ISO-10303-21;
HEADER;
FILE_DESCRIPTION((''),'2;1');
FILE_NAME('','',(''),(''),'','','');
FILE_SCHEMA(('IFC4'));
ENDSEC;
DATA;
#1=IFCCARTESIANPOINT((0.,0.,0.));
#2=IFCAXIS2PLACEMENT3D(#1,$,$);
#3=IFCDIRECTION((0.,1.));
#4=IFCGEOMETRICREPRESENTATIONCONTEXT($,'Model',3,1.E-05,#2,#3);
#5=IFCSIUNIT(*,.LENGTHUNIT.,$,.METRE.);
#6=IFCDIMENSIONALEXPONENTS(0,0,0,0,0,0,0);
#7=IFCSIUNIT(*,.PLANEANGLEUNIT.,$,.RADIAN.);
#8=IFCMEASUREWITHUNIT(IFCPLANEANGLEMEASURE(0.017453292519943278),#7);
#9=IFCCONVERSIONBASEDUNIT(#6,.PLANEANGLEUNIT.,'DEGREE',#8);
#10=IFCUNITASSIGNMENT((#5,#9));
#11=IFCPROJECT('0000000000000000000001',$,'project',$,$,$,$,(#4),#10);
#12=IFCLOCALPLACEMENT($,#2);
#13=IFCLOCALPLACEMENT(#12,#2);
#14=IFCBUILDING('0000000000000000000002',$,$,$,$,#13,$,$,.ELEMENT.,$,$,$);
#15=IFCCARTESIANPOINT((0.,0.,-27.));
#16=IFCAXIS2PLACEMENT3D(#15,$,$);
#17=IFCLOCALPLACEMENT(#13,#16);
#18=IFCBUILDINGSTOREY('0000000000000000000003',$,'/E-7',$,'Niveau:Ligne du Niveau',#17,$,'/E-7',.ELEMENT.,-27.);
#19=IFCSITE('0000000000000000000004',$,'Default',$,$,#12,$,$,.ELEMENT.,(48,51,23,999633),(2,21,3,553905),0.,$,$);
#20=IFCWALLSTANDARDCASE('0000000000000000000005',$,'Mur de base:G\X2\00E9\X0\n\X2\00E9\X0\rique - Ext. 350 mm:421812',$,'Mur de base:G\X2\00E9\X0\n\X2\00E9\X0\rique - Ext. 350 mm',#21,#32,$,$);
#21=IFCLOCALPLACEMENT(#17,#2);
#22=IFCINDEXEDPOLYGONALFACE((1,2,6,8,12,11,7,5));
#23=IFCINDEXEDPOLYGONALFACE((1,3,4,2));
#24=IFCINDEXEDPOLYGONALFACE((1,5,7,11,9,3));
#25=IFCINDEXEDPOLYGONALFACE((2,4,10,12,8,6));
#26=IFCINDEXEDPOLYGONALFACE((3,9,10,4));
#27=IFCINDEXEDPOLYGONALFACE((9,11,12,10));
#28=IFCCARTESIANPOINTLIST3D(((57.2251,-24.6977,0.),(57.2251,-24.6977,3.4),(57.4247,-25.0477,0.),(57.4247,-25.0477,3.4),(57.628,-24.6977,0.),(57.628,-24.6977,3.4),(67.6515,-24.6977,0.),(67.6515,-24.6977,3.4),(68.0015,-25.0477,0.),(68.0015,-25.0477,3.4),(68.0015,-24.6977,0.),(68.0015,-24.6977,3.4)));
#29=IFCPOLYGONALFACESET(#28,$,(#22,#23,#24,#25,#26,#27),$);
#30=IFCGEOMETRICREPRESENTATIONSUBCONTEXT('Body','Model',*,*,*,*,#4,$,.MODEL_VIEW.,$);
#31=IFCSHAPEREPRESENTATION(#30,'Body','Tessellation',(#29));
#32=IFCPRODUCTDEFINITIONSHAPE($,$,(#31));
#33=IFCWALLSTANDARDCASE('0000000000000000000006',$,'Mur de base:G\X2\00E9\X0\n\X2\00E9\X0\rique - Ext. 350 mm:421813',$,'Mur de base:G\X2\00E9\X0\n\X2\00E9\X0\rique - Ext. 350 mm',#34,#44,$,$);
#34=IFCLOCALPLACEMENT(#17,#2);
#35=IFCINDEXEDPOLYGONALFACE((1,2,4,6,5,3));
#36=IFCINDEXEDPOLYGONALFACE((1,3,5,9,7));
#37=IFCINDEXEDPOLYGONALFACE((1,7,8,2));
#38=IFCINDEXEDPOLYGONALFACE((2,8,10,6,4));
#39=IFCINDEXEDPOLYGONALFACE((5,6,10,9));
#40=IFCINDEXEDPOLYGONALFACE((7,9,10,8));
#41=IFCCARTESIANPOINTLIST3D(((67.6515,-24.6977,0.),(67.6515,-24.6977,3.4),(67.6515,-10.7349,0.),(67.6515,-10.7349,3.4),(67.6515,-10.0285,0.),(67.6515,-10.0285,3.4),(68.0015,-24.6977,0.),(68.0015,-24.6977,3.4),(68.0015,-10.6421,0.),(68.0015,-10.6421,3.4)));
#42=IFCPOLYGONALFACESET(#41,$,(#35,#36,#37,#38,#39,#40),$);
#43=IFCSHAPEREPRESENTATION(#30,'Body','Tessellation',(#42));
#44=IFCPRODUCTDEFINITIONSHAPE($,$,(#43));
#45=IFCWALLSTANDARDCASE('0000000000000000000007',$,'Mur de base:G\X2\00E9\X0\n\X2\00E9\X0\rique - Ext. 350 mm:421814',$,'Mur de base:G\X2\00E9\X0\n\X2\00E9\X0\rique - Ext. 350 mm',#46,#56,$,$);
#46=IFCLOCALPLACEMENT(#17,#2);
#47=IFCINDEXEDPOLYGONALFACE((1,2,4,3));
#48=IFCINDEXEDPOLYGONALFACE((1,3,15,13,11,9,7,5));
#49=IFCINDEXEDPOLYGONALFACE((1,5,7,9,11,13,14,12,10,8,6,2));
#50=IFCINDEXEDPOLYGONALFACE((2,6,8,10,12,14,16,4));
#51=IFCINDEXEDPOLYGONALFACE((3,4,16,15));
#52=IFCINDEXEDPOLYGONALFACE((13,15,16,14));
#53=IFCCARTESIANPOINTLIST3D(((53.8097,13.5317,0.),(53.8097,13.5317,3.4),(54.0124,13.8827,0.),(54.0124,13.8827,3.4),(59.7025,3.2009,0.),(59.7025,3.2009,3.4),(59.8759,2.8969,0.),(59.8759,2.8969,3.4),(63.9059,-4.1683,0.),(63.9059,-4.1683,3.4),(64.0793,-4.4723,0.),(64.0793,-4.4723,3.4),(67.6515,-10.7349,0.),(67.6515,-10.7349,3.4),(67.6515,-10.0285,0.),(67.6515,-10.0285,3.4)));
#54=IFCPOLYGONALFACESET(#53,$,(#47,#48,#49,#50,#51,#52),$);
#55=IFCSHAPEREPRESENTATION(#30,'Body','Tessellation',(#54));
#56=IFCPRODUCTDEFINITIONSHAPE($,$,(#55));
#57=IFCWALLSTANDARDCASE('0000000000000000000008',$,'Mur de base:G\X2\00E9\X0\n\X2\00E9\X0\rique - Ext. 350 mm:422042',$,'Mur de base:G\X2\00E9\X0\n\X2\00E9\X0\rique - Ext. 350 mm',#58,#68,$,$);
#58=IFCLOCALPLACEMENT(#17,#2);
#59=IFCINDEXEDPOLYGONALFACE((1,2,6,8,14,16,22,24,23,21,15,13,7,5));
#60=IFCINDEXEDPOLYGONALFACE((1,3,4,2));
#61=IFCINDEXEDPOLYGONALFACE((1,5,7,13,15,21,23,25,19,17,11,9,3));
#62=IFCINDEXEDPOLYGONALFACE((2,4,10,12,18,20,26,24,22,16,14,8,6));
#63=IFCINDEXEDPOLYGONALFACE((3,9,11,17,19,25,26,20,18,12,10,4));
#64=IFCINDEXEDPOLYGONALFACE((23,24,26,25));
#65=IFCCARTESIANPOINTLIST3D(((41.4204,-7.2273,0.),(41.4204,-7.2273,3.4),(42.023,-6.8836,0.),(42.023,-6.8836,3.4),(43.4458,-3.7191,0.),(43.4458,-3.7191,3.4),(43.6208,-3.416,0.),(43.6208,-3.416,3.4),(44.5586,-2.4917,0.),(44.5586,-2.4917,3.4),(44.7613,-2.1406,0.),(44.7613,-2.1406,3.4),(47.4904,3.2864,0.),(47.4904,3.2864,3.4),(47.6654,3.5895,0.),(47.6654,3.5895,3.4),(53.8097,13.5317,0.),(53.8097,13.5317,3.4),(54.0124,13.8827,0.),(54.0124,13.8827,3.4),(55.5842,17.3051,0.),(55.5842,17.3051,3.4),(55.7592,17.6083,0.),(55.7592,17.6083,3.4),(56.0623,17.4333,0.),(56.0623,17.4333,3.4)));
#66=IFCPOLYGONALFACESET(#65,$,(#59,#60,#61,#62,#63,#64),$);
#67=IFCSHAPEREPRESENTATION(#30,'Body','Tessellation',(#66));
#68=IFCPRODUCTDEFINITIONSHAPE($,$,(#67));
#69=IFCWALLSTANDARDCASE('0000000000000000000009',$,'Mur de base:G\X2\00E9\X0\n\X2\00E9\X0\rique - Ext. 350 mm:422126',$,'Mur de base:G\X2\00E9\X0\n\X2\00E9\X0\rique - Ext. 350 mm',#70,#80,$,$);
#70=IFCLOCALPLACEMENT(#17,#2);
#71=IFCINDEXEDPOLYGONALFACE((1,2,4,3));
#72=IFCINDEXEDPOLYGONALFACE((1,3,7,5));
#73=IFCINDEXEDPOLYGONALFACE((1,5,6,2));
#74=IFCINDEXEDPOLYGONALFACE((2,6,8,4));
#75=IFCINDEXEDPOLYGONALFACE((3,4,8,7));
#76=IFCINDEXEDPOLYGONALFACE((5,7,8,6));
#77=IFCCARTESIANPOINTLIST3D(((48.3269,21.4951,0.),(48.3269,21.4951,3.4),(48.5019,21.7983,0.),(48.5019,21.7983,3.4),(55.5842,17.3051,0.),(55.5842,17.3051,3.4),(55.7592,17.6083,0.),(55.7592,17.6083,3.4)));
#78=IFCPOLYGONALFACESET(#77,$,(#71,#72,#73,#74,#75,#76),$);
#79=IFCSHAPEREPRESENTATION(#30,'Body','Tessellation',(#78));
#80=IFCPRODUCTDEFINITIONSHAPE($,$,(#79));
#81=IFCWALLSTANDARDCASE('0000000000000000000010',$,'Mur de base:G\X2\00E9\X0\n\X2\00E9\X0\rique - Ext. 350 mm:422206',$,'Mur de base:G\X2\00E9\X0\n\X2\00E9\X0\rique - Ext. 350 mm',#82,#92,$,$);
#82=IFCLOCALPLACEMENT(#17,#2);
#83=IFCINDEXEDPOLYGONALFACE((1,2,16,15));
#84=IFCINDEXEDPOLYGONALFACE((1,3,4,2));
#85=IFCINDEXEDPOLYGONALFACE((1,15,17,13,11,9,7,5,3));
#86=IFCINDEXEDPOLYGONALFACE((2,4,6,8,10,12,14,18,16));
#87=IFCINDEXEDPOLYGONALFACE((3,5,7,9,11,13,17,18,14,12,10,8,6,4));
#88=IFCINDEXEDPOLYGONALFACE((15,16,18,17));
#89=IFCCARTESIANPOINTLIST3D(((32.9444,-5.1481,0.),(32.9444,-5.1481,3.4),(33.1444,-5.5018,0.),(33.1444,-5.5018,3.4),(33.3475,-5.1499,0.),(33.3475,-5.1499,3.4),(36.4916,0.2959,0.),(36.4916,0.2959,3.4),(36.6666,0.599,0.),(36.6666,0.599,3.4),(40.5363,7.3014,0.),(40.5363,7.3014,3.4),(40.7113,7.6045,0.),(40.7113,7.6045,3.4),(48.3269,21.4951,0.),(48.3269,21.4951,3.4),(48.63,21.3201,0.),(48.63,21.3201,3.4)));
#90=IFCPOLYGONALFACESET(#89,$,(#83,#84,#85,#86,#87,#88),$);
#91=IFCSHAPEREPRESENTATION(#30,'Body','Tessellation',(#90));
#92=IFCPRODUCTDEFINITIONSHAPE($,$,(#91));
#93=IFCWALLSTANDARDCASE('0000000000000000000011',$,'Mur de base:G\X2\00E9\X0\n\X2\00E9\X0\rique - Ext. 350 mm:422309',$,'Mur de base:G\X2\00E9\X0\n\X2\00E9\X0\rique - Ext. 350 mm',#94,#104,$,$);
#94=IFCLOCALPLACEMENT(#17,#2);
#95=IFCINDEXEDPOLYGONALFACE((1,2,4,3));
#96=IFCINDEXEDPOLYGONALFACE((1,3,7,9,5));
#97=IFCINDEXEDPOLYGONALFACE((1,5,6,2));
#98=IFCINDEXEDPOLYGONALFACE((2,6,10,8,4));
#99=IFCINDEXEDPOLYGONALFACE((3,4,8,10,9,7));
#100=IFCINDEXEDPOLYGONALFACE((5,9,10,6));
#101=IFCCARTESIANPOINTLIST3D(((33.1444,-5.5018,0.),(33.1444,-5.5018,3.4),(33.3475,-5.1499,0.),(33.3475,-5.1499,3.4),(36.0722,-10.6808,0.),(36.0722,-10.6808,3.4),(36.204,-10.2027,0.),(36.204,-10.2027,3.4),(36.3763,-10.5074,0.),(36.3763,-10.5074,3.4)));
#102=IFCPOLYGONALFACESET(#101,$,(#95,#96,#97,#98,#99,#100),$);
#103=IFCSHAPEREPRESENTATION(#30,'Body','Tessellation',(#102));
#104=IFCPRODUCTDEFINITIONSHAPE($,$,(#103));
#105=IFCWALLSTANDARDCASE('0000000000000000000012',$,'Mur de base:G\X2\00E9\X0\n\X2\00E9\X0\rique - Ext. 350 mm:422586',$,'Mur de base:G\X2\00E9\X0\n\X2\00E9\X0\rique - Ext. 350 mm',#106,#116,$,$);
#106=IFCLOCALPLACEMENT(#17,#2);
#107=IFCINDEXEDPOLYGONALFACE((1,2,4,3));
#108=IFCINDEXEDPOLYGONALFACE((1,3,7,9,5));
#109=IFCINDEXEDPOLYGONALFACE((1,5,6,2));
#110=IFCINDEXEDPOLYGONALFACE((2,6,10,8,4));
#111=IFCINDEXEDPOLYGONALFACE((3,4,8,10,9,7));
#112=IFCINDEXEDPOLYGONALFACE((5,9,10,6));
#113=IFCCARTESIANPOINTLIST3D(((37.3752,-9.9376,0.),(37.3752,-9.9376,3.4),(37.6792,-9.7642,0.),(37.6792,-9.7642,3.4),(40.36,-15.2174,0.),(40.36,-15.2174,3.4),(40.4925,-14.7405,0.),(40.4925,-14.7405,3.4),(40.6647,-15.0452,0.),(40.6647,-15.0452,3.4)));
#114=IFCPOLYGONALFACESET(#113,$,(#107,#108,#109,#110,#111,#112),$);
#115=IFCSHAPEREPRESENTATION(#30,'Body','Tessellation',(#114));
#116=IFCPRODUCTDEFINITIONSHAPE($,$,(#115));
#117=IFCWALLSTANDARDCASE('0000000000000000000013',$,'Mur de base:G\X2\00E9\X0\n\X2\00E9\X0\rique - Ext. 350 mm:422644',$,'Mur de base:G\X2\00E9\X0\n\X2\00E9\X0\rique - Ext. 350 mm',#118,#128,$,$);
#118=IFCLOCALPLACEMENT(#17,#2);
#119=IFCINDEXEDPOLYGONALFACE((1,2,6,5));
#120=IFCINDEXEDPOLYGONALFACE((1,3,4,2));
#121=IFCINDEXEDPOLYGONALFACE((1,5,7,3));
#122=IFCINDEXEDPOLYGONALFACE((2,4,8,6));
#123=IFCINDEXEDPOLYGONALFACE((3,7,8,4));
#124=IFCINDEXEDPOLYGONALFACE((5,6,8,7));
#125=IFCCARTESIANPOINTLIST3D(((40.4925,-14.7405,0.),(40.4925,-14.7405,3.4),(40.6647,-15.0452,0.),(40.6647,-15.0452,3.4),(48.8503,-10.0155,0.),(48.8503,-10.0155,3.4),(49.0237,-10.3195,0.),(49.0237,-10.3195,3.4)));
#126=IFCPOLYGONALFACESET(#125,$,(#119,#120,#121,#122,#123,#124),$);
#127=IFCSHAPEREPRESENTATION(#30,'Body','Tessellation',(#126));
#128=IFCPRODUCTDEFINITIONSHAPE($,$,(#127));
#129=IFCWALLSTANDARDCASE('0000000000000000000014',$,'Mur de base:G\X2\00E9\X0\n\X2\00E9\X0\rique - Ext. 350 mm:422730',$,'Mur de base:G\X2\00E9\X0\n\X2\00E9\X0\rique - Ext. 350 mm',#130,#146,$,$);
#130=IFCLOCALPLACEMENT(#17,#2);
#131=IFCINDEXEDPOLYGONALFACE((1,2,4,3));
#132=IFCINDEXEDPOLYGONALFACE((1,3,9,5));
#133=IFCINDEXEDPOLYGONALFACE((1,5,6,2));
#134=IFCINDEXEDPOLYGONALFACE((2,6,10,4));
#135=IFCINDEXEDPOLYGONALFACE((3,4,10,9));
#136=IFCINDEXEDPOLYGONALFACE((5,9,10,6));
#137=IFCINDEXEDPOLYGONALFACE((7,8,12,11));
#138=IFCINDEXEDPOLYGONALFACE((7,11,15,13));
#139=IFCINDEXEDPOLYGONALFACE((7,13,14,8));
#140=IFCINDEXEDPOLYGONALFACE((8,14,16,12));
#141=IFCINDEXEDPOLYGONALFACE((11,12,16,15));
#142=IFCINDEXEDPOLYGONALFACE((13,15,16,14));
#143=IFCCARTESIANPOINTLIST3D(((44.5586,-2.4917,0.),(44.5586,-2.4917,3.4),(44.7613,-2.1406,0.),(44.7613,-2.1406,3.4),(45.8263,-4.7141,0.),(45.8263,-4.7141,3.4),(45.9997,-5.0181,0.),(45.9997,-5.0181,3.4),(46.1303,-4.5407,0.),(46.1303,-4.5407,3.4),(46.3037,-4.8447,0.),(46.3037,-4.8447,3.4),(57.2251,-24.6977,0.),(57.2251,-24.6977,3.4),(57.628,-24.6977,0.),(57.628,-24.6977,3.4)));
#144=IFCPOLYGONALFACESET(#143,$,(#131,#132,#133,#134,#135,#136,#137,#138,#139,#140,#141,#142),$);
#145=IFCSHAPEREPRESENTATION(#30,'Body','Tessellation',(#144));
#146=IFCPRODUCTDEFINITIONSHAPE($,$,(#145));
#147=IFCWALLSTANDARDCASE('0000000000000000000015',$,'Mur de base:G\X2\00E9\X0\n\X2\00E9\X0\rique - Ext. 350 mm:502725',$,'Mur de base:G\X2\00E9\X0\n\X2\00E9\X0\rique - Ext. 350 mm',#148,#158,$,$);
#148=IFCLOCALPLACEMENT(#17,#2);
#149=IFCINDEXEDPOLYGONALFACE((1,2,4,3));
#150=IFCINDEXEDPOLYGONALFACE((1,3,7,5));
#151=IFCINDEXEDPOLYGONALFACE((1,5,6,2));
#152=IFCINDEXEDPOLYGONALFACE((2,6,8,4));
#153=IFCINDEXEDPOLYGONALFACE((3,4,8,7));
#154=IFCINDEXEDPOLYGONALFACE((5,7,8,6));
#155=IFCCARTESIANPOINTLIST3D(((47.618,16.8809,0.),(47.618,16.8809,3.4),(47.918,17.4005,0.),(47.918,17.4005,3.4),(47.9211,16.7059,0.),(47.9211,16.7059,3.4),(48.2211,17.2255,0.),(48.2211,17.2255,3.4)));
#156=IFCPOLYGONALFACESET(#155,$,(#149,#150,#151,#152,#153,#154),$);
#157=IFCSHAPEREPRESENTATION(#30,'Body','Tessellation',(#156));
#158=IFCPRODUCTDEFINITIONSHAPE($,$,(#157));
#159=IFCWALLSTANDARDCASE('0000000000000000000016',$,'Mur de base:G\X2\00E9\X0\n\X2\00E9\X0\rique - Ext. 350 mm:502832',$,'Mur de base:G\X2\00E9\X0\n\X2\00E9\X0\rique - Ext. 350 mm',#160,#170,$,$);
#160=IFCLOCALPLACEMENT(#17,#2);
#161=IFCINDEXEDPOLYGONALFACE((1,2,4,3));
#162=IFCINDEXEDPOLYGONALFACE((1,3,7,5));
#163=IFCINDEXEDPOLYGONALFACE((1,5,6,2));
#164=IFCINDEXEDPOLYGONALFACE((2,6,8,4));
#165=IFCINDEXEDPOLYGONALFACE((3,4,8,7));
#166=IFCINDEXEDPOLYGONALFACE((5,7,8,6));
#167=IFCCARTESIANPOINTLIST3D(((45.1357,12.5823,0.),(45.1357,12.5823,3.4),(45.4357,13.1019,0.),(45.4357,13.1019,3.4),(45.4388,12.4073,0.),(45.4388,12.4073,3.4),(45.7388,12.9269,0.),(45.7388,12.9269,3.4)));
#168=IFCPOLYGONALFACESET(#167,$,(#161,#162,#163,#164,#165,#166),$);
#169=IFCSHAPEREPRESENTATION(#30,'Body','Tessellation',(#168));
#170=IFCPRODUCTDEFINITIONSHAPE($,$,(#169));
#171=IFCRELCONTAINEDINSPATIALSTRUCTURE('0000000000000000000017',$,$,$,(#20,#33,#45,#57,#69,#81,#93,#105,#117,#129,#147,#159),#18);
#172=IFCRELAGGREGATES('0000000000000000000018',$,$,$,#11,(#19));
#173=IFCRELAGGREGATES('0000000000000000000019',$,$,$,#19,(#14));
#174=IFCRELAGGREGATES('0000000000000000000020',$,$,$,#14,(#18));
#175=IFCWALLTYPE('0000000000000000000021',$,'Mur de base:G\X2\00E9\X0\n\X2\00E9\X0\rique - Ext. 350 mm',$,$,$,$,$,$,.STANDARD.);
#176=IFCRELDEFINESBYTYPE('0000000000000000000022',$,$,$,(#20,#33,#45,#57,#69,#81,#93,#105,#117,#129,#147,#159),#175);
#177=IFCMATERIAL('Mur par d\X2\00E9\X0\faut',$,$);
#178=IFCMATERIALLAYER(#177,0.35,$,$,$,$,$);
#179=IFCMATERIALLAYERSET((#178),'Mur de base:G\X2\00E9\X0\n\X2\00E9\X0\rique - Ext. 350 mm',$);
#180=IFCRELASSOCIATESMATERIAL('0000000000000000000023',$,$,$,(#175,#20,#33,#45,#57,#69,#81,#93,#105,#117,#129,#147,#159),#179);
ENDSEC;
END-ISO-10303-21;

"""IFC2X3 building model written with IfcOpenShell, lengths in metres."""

from ifc_helpers import new_model, entity, si_unit, converted_unit, direction, frame, frame_2d, origin, place, context, subcontext, project, spatial, polyline, rectangle, outline, extrude, material, layer, layer_set, layer_usage, type_object, element, save


model = new_model("IFC2X3")

# Units and contexts
model_context = context("Model", 3, precision=1e-05, world=origin(), true_north=direction((0.0, 1.0)))
body_context = subcontext(model_context, "Body", "Model", "MODEL_VIEW")
ifc_project = project(units=[si_unit("LENGTHUNIT", "METRE"), converted_unit("PLANEANGLEUNIT", "DEGREE", entity("IfcPlaneAngleMeasure", 0.017453292519943278), si_unit("PLANEANGLEUNIT", "RADIAN"), dimensions=[0, 0, 0, 0, 0, 0, 0])], contexts=[model_context])

# Site, building, storey
site_placement = place(None, origin())
site = spatial("IfcSite", under=ifc_project, at=site_placement, Name="Default", CompositionType="ELEMENT", RefLatitude=(48, 51, 23, 999633), RefLongitude=(2, 21, 3, 553905), RefElevation=0.0)
building_placement = place(site_placement, origin())
building = spatial("IfcBuilding", under=site, at=building_placement, CompositionType="ELEMENT")
storey_placement = place(building_placement, frame((0.0, 0.0, -27.0)))
storey = spatial("IfcBuildingStorey", under=building, at=storey_placement, Name="/E-7", ObjectType="Niveau:Ligne du Niveau", LongName="/E-7", CompositionType="ELEMENT", Elevation=-27.0)

# Walls
ifc_material_1 = material(Name="Mur par défaut")
ifc_layer_1 = layer(ifc_material_1, 0.35)
ifc_layer_set_1 = layer_set([ifc_layer_1], Name="Mur de base:Générique - Ext. 350 mm")
ifc_layer_usage_1 = layer_usage(ifc_layer_set_1, "AXIS2", "NEGATIVE", 0.175)
wall_type_1 = type_object("IfcWallType", Name="Mur de base:Générique - Ext. 350 mm", PredefinedType="STANDARD", material=ifc_layer_set_1)
wall_1_placement = place(storey_placement, frame((57.2251, -24.8727, 0.0)))
element("IfcWallStandardCase", 1, at=wall_1_placement, inside=storey, type_object=wall_type_1, material=ifc_layer_usage_1, Name="Mur de base:Générique - Ext. 350 mm:421812", ObjectType="Mur de base:Générique - Ext. 350 mm", context=body_context, shape_type="SweptSolid", body=[
    extrude(outline(polyline([(10.7765, -0.175), (10.7765, 0.175), (10.4265, 0.175), (0.4029, 0.175), (0.0, 0.175), (0.1996, -0.175), (10.7765, -0.175)])), origin(), (0.0, 0.0, 1.0), 3.4),
])
ifc_layer_usage_2 = layer_usage(ifc_layer_set_1, "AXIS2", "NEGATIVE", 0.175)
wall_2_placement = place(storey_placement, frame((67.8265, -24.6977, 0.0), z_axis=(0.0, 0.0, 1.0), x_axis=(0.0, 1.0, 0.0)))
element("IfcWallStandardCase", 2, at=wall_2_placement, inside=storey, type_object=wall_type_1, material=ifc_layer_usage_2, Name="Mur de base:Générique - Ext. 350 mm:421813", ObjectType="Mur de base:Générique - Ext. 350 mm", context=body_context, shape_type="SweptSolid", body=[
    extrude(outline(polyline([(14.0556, -0.175), (14.6692, 0.175), (13.9628, 0.175), (0.0, 0.175), (0.0, -0.175), (14.0556, -0.175)])), origin(), (0.0, 0.0, 1.0), 3.4),
])
ifc_layer_usage_3 = layer_usage(ifc_layer_set_1, "AXIS2", "NEGATIVE", 0.175)
wall_3_placement = place(storey_placement, frame((67.8035, -10.6482, 0.0), z_axis=(0.0, 0.0, 1.0), x_axis=(-0.495469, 0.868625, 0.0)))
element("IfcWallStandardCase", 3, at=wall_3_placement, inside=storey, type_object=wall_type_1, material=ifc_layer_usage_3, Name="Mur de base:Générique - Ext. 350 mm:421814", ObjectType="Mur de base:Générique - Ext. 350 mm", context=body_context, shape_type="SweptSolid", body=[
    extrude(outline(polyline([(28.1412, -0.175), (27.9367, 0.175), (16.0435, 0.175), (15.6935, 0.175), (7.5597, 0.175), (7.2097, 0.175), (0.0, 0.175), (0.6136, -0.175), (28.1412, -0.175)])), origin(), (0.0, 0.0, 1.0), 3.4),
])
ifc_layer_usage_4 = layer_usage(ifc_layer_set_1, "AXIS2", "NEGATIVE", 0.175)
wall_4_placement = place(storey_placement, frame((41.572, -7.3148, 0.0), z_axis=(0.0, 0.0, 1.0), x_axis=(0.5, 0.866025, 0.0)))
element("IfcWallStandardCase", 4, at=wall_4_placement, inside=storey, type_object=wall_type_1, material=ifc_layer_usage_4, Name="Mur de base:Générique - Ext. 350 mm:422042", ObjectType="Mur de base:Générique - Ext. 350 mm", context=body_context, shape_type="SweptSolid", body=[
    extrude(outline(polyline([(28.6776, -0.175), (28.6776, 0.175), (28.3276, 0.175), (12.4901, 0.175), (12.1401, 0.175), (4.4008, 0.175), (4.0508, 0.175), (0.0, 0.175), (0.599, -0.175), (5.6703, -0.175), (6.0756, -0.175), (24.1725, -0.175), (24.5778, -0.175), (28.6776, -0.175)])), origin(), (0.0, 0.0, 1.0), 3.4),
])
ifc_layer_usage_5 = layer_usage(ifc_layer_set_1, "AXIS2", "NEGATIVE", 0.175)
wall_5_placement = place(storey_placement, frame((55.6717, 17.4567, 0.0), z_axis=(0.0, 0.0, 1.0), x_axis=(-0.866025, 0.5, 0.0)))
element("IfcWallStandardCase", 5, at=wall_5_placement, inside=storey, type_object=wall_type_1, material=ifc_layer_usage_5, Name="Mur de base:Générique - Ext. 350 mm:422126", ObjectType="Mur de base:Générique - Ext. 350 mm", context=body_context, shape_type="SweptSolid", body=[
    extrude(rectangle(XDim=8.38, YDim=0.35, at=frame_2d((4.19, 0.0), x_axis=(-1.0, 0.0))), origin(), (0.0, 0.0, 1.0), 3.4),
])
ifc_layer_usage_6 = layer_usage(ifc_layer_set_1, "AXIS2", "NEGATIVE", 0.175)
wall_6_placement = place(storey_placement, frame((48.4785, 21.4076, 0.0), z_axis=(0.0, 0.0, 1.0), x_axis=(-0.5, -0.866025, 0.0)))
element("IfcWallStandardCase", 6, at=wall_6_placement, inside=storey, type_object=wall_type_1, material=ifc_layer_usage_6, Name="Mur de base:Générique - Ext. 350 mm:422206", ObjectType="Mur de base:Générique - Ext. 350 mm", context=body_context, shape_type="SweptSolid", body=[
    extrude(outline(polyline([(30.765, -0.175), (30.9713, 0.175), (30.565, 0.175), (24.2768, 0.175), (23.9268, 0.175), (16.1875, 0.175), (15.8375, 0.175), (0.0, 0.175), (0.0, -0.175), (30.765, -0.175)])), origin(), (0.0, 0.0, 1.0), 3.4),
])
ifc_layer_usage_7 = layer_usage(ifc_layer_set_1, "AXIS2", "NEGATIVE", 0.175)
wall_7_placement = place(storey_placement, frame((33.1952, -5.2361, 0.0), z_axis=(0.0, 0.0, 1.0), x_axis=(0.492133, -0.87052, 0.0)))
element("IfcWallStandardCase", 7, at=wall_7_placement, inside=storey, type_object=wall_type_1, material=ifc_layer_usage_7, Name="Mur de base:Générique - Ext. 350 mm:422309", ObjectType="Mur de base:Générique - Ext. 350 mm", context=body_context, shape_type="SweptSolid", body=[
    extrude(outline(polyline([(6.1557, -0.175), (6.1543, 0.175), (5.8043, 0.175), (0.0, 0.175), (0.2063, -0.175), (6.1557, -0.175)])), origin(), (0.0, 0.0, 1.0), 3.4),
])

# Walls
ifc_layer_usage_8 = layer_usage(ifc_layer_set_1, "AXIS2", "NEGATIVE", 0.175)
wall_8_placement = place(storey_placement, frame((37.5269, -9.8503, 0.0), z_axis=(0.0, 0.0, 1.0), x_axis=(0.492133, -0.87052, 0.0)))
element("IfcWallStandardCase", 8, at=wall_8_placement, inside=storey, type_object=wall_type_1, material=ifc_layer_usage_8, Name="Mur de base:Générique - Ext. 350 mm:422586", ObjectType="Mur de base:Générique - Ext. 350 mm", context=body_context, shape_type="SweptSolid", body=[
    extrude(outline(polyline([(6.0664, -0.175), (6.0664, 0.175), (5.7164, 0.175), (0.0, 0.175), (0.0013, -0.175), (6.0664, -0.175)])), origin(), (0.0, 0.0, 1.0), 3.4),
])
ifc_layer_usage_9 = layer_usage(ifc_layer_set_1, "AXIS2", "NEGATIVE", 0.175)
wall_9_placement = place(storey_placement, frame((40.5786, -14.8928, 0.0), z_axis=(0.0, 0.0, 1.0), x_axis=(0.87052, 0.492133, 0.0)))
element("IfcWallStandardCase", 9, at=wall_9_placement, inside=storey, type_object=wall_type_1, material=ifc_layer_usage_9, Name="Mur de base:Générique - Ext. 350 mm:422644", ObjectType="Mur de base:Générique - Ext. 350 mm", context=body_context, shape_type="SweptSolid", body=[
    extrude(outline(polyline([(9.6023, -0.175), (9.6009, 0.175), (0.0, 0.175), (0.0, -0.175), (9.6023, -0.175)])), origin(), (0.0, 0.0, 1.0), 3.4),
])

# Wall, opening
ifc_layer_usage_10 = layer_usage(ifc_layer_set_1, "AXIS2", "NEGATIVE", 0.175)
wall_10_placement = place(storey_placement, frame((44.6093, -2.2273, 0.0), z_axis=(0.0, 0.0, 1.0), x_axis=(0.495469, -0.868625, 0.0)))
wall_10 = element("IfcWallStandardCase", 10, at=wall_10_placement, inside=storey, type_object=wall_type_1, material=ifc_layer_usage_10, Name="Mur de base:Générique - Ext. 350 mm:422730", ObjectType="Mur de base:Générique - Ext. 350 mm", context=body_context, shape_type="SweptSolid", body=[
    extrude(outline(polyline([(0.0, 0.175), (0.2045, -0.175), (25.769, -0.175), (25.9687, 0.175), (0.0, 0.175)])), origin(), (0.0, 0.0, 1.0), 3.4),
])
opening_1_placement = place(storey_placement, frame((44.6093, -2.2273, 0.0), z_axis=(0.0, 0.0, 1.0), x_axis=(0.495469, -0.868625, 0.0)))
element("IfcOpeningElement", 11, at=opening_1_placement, cuts=wall_10, ObjectType="Opening", context=body_context, shape_type="SweptSolid", body=[
    extrude(rectangle(XDim=3.4, YDim=0.35, at=frame_2d((0.0, 0.0), x_axis=(1.0, 0.0))), frame((3.1131, 0.0, 1.7), z_axis=(-1.0, 0.0, 0.0), x_axis=(0.0, 0.0, 1.0)), (0.0, 0.0, 1.0), 0.35),
])

# Walls
ifc_layer_usage_11 = layer_usage(ifc_layer_set_1, "AXIS2", "NEGATIVE", 0.175)
wall_11_placement = place(storey_placement, frame((48.0695, 17.313, 0.0), z_axis=(0.0, 0.0, 1.0), x_axis=(-0.5, -0.866025, 0.0)))
element("IfcWallStandardCase", 12, at=wall_11_placement, inside=storey, type_object=wall_type_1, material=ifc_layer_usage_11, Name="Mur de base:Générique - Ext. 350 mm:502725", ObjectType="Mur de base:Générique - Ext. 350 mm", context=body_context, shape_type="SweptSolid", body=[
    extrude(rectangle(XDim=0.6, YDim=0.35, at=frame_2d((0.3, 0.0), x_axis=(-1.0, 0.0))), origin(), (0.0, 0.0, 1.0), 3.4),
])
ifc_layer_usage_12 = layer_usage(ifc_layer_set_1, "AXIS2", "NEGATIVE", 0.175)
wall_12_placement = place(storey_placement, frame((45.5873, 13.0144, 0.0), z_axis=(0.0, 0.0, 1.0), x_axis=(-0.5, -0.866025, 0.0)))
element("IfcWallStandardCase", 13, at=wall_12_placement, inside=storey, type_object=wall_type_1, material=ifc_layer_usage_12, Name="Mur de base:Générique - Ext. 350 mm:502832", ObjectType="Mur de base:Générique - Ext. 350 mm", context=body_context, shape_type="SweptSolid", body=[
    extrude(rectangle(XDim=0.6, YDim=0.35, at=frame_2d((0.3, 0.0), x_axis=(-1.0, 0.0))), origin(), (0.0, 0.0, 1.0), 3.4),
])

save(model, "model.ifc")
